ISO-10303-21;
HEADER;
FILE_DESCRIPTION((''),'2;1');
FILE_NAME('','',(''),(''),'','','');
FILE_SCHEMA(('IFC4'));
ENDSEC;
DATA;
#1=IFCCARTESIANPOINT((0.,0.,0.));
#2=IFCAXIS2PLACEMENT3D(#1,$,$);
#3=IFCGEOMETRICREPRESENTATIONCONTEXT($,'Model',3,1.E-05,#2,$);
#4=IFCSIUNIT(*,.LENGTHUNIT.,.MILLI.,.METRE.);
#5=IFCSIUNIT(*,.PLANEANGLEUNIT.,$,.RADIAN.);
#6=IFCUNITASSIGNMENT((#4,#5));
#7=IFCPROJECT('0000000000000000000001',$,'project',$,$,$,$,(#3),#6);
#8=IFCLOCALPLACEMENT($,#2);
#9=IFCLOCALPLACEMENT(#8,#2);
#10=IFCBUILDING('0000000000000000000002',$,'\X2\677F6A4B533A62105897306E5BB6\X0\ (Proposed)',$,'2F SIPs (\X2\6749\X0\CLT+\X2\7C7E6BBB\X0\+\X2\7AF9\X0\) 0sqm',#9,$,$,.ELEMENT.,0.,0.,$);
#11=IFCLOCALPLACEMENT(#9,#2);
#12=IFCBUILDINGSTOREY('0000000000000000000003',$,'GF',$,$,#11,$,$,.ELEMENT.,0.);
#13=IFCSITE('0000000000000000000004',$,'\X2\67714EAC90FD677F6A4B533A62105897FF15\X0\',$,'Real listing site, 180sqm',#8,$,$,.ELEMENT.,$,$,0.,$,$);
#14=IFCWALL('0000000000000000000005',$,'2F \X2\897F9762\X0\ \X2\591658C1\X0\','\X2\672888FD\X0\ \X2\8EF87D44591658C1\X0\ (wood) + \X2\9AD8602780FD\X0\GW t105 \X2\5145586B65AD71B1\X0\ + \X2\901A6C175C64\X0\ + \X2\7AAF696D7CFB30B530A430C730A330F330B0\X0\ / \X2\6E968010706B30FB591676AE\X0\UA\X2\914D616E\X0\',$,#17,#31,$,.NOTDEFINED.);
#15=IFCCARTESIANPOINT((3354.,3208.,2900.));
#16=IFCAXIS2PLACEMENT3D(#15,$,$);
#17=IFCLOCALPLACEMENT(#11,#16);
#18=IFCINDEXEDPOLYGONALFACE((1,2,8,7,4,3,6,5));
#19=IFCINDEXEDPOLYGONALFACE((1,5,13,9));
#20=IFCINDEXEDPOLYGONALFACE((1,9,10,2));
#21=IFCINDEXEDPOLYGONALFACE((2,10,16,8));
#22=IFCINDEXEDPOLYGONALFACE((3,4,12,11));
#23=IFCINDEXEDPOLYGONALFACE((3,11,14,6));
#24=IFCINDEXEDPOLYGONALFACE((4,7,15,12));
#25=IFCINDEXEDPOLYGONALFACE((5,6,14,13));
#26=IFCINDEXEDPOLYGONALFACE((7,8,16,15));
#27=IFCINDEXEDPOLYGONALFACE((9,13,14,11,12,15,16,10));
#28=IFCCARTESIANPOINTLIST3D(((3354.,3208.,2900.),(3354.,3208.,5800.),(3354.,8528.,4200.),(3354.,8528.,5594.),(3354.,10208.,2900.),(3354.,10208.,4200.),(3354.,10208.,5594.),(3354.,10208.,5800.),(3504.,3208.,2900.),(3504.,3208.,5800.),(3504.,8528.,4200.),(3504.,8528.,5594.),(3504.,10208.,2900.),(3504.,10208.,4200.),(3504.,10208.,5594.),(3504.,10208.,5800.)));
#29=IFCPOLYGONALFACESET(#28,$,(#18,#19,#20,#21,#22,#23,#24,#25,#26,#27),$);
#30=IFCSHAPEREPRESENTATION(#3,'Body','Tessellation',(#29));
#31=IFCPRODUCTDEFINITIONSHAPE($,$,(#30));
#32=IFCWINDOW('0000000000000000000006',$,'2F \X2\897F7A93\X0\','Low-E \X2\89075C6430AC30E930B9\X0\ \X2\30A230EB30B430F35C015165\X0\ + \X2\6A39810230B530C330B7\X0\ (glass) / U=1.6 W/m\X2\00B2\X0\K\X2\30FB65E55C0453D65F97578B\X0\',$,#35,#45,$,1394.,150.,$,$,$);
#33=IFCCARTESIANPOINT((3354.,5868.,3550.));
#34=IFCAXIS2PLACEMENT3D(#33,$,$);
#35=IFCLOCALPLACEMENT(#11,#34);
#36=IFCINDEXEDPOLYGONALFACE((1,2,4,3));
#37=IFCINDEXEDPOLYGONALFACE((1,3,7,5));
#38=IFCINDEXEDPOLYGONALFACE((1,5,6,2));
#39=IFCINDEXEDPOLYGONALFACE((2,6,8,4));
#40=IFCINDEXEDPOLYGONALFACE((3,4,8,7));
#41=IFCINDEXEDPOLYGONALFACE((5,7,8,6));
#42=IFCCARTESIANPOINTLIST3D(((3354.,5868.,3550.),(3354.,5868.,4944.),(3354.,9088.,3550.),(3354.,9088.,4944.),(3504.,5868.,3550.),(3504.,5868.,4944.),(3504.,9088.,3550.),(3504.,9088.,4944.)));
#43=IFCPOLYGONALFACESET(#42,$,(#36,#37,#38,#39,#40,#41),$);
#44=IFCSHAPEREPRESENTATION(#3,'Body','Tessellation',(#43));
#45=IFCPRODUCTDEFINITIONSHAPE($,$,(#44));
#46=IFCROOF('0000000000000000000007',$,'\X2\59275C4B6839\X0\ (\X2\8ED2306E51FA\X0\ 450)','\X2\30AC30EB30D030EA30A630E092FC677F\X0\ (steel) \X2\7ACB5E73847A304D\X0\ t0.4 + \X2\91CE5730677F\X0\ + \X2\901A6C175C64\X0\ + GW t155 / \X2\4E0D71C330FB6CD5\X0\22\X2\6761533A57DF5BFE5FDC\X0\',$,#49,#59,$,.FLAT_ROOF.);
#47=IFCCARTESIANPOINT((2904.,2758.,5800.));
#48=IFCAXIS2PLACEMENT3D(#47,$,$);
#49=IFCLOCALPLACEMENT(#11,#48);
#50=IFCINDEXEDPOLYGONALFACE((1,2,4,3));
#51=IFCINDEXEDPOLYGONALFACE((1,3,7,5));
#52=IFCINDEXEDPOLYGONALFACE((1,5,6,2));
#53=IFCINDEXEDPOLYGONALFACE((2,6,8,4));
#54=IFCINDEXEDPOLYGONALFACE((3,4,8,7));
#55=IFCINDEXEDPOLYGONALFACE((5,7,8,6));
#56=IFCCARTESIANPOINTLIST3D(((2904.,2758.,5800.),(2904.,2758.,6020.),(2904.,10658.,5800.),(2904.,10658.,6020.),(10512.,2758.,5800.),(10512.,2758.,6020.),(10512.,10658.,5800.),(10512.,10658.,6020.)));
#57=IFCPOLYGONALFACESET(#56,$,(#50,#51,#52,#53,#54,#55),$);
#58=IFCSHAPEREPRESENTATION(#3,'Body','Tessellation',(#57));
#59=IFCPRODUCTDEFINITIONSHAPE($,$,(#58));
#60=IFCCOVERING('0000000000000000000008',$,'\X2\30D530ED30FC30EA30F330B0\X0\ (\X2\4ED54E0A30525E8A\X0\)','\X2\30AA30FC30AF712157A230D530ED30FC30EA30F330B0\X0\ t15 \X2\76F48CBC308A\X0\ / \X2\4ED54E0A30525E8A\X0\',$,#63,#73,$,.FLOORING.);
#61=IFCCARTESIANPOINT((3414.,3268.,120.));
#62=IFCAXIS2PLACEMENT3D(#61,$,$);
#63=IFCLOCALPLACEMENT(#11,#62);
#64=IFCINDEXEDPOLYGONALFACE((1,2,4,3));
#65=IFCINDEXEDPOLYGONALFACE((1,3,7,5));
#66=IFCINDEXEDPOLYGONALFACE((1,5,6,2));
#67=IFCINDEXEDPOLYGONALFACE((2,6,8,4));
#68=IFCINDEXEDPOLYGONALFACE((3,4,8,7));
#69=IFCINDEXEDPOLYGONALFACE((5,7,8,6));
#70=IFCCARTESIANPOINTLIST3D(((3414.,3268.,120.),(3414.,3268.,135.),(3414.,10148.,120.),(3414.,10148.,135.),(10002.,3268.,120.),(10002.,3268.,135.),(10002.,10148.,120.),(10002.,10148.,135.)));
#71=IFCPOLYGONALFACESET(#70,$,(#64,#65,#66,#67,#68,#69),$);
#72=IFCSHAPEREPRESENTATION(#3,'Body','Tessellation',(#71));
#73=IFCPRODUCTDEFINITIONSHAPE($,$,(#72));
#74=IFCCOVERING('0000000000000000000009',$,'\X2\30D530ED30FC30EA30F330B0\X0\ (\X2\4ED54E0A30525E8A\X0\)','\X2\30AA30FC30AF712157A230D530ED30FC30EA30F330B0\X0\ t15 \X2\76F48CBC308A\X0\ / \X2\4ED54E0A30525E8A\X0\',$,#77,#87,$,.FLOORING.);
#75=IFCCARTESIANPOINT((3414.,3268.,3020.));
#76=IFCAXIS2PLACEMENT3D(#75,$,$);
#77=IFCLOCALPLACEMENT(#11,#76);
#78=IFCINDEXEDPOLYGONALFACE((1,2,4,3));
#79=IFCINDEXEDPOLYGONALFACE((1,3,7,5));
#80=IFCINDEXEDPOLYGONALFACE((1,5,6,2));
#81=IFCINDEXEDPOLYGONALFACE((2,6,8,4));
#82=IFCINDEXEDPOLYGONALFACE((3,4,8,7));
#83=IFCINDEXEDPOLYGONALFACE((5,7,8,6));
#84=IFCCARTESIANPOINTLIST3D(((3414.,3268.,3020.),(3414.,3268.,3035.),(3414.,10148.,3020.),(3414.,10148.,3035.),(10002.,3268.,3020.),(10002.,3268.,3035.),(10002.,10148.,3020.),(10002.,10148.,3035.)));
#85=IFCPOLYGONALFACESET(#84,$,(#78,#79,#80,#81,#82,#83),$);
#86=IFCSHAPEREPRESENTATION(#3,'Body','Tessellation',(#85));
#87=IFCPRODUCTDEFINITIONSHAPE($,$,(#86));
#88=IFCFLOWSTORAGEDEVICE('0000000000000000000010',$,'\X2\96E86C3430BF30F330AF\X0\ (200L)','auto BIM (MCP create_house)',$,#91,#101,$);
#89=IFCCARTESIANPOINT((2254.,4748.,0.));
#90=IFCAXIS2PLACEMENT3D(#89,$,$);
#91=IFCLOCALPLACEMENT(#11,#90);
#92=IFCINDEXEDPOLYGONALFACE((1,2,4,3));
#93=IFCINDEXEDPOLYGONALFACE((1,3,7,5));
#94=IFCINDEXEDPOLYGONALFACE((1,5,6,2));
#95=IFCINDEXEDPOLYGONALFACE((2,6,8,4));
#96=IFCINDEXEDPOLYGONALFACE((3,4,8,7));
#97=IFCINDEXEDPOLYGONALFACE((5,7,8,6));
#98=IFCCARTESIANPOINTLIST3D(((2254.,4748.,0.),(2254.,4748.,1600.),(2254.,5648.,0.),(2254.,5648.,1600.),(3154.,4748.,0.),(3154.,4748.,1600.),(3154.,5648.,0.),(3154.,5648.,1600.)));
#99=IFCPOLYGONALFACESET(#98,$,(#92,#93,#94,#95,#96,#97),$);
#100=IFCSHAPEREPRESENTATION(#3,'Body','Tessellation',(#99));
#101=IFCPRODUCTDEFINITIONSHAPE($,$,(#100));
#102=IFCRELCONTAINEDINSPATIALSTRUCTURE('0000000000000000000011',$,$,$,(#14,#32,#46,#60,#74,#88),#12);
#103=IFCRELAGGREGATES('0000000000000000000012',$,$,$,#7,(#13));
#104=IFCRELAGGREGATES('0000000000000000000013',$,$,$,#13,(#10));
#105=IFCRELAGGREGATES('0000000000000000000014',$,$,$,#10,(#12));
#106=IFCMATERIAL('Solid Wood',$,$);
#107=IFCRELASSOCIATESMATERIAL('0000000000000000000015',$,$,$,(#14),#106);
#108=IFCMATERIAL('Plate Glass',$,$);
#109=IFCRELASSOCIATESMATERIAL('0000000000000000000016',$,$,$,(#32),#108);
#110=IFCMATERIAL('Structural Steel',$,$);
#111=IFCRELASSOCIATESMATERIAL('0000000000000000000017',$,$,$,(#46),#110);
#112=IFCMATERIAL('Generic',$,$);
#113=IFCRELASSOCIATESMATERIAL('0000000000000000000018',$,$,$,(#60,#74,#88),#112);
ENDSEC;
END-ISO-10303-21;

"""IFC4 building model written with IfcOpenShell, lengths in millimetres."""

from ifc_helpers import new_model, si_unit, frame, frame_2d, origin, place, context, project, spatial, rectangle, extrude, material, element, fill, save


model = new_model("IFC4")

# Units and contexts
model_context = context("Model", 3, precision=1e-05, world=origin())
ifc_project = project(units=[si_unit("LENGTHUNIT", "METRE", prefix="MILLI"), si_unit("PLANEANGLEUNIT", "RADIAN")], contexts=[model_context])

# Site, building, storey
site_placement = place(None, origin())
site = spatial("IfcSite", under=ifc_project, at=site_placement, Name="東京都板橋区成増５", ObjectType="Real listing site, 180sqm", CompositionType="ELEMENT", RefElevation=0.0)
building_placement = place(site_placement, origin())
building = spatial("IfcBuilding", under=site, at=building_placement, Name="板橋区成増の家 (Proposed)", ObjectType="2F SIPs (杉CLT+籾殻+竹) 0sqm", CompositionType="ELEMENT", ElevationOfRefHeight=0.0, ElevationOfTerrain=0.0)
storey_placement = place(building_placement, origin())
storey = spatial("IfcBuildingStorey", under=building, at=storey_placement, Name="GF", CompositionType="ELEMENT", Elevation=0.0)

# Shared definitions
ifc_material_1 = material(Name="Solid Wood")

# Shared definitions
ifc_material_2 = material(Name="Plate Glass")

# Wall, opening, window
wall_1_placement = place(storey_placement, frame((3354.0, 3208.0, 2900.0)))
wall_1 = element("IfcWall", 1, at=wall_1_placement, inside=storey, material=ifc_material_1, Name="2F 西面 外壁", Description="木製 軸組外壁 (wood) + 高性能GW t105 充填断熱 + 通気層 + 窯業系サイディング / 準耐火・外皮UA配慮", PredefinedType="NOTDEFINED", context=model_context, shape_type="SweptSolid", body=[
    extrude(rectangle(XDim=150.0, YDim=7000.0, at=frame_2d((75.0, 3500.0))), frame((3354.0, 3208.0, 2900.0)), (0.0, 0.0, 1.0), 2900.0),
])
opening_1_placement = place(storey_placement, frame((3354.0, 5868.0, 3550.0)))
opening_1 = element("IfcOpeningElement", 2, at=opening_1_placement, cuts=wall_1, PredefinedType="NOTDEFINED", context=model_context, shape_type="SweptSolid", body=[
    extrude(rectangle(XDim=150.0, YDim=3220.0, at=frame_2d((75.0, 1610.0))), frame((3354.0, 5868.0, 3550.0)), (0.0, 0.0, 1.0), 1394.0),
])
window_1_placement = place(storey_placement, frame((3354.0, 5868.0, 3550.0)))
window_1 = element("IfcWindow", 3, at=window_1_placement, inside=storey, material=ifc_material_2, Name="2F 西窓", Description="Low-E 複層ガラス アルゴン封入 + 樹脂サッシ (glass) / U=1.6 W/m²K・日射取得型", OverallHeight=1394.0, OverallWidth=150.0, context=model_context, shape_type="SweptSolid", body=[
    extrude(rectangle(XDim=150.0, YDim=3220.0, at=frame_2d((75.0, 1610.0))), frame((3354.0, 5868.0, 3550.0)), (0.0, 0.0, 1.0), 1394.0),
])
fill(opening_1, window_1)

# Roof
ifc_material_3 = material(Name="Structural Steel")
roof_placement = place(storey_placement, frame((2904.0, 2758.0, 5800.0)))
element("IfcRoof", 4, at=roof_placement, inside=storey, material=ifc_material_3, Name="大屋根 (軒の出 450)", Description="ガルバリウム鋼板 (steel) 立平葺き t0.4 + 野地板 + 通気層 + GW t155 / 不燃・法22条区域対応", PredefinedType="FLAT_ROOF", context=model_context, shape_type="SweptSolid", body=[
    extrude(rectangle(XDim=7608.0, YDim=7900.0, at=frame_2d((3804.0, 3950.0))), frame((2904.0, 2758.0, 5800.0)), (0.0, 0.0, 1.0), 220.0),
])

# Coverings
ifc_material_4 = material(Name="Generic")
covering_1_placement = place(storey_placement, frame((3414.0, 3268.0, 120.0)))
element("IfcCovering", 5, at=covering_1_placement, inside=storey, material=ifc_material_4, Name="フローリング (仕上げ床)", Description="オーク無垢フローリング t15 直貼り / 仕上げ床", PredefinedType="FLOORING", context=model_context, shape_type="SweptSolid", body=[
    extrude(rectangle(XDim=6588.0, YDim=6880.0, at=frame_2d((3294.0, 3440.0))), frame((3414.0, 3268.0, 120.0)), (0.0, 0.0, 1.0), 15.0),
])
covering_2_placement = place(storey_placement, frame((3414.0, 3268.0, 3020.0)))
element("IfcCovering", 6, at=covering_2_placement, inside=storey, material=ifc_material_4, Name="フローリング (仕上げ床)", Description="オーク無垢フローリング t15 直貼り / 仕上げ床", PredefinedType="FLOORING", context=model_context, shape_type="SweptSolid", body=[
    extrude(rectangle(XDim=6588.0, YDim=6880.0, at=frame_2d((3294.0, 3440.0))), frame((3414.0, 3268.0, 3020.0)), (0.0, 0.0, 1.0), 15.0),
])

# Flow storage device
flow_storage_device_placement = place(storey_placement, frame((2254.0, 4748.0, 0.0)))
element("IfcFlowStorageDevice", 7, at=flow_storage_device_placement, inside=storey, material=ifc_material_4, Name="雨水タンク (200L)", Description="auto BIM (MCP create_house)", context=model_context, shape_type="SweptSolid", body=[
    extrude(rectangle(XDim=900.0, YDim=900.0, at=frame_2d((450.0, 450.0))), frame((2254.0, 4748.0, 0.0)), (0.0, 0.0, 1.0), 1600.0),
])

save(model, "model.ifc")
